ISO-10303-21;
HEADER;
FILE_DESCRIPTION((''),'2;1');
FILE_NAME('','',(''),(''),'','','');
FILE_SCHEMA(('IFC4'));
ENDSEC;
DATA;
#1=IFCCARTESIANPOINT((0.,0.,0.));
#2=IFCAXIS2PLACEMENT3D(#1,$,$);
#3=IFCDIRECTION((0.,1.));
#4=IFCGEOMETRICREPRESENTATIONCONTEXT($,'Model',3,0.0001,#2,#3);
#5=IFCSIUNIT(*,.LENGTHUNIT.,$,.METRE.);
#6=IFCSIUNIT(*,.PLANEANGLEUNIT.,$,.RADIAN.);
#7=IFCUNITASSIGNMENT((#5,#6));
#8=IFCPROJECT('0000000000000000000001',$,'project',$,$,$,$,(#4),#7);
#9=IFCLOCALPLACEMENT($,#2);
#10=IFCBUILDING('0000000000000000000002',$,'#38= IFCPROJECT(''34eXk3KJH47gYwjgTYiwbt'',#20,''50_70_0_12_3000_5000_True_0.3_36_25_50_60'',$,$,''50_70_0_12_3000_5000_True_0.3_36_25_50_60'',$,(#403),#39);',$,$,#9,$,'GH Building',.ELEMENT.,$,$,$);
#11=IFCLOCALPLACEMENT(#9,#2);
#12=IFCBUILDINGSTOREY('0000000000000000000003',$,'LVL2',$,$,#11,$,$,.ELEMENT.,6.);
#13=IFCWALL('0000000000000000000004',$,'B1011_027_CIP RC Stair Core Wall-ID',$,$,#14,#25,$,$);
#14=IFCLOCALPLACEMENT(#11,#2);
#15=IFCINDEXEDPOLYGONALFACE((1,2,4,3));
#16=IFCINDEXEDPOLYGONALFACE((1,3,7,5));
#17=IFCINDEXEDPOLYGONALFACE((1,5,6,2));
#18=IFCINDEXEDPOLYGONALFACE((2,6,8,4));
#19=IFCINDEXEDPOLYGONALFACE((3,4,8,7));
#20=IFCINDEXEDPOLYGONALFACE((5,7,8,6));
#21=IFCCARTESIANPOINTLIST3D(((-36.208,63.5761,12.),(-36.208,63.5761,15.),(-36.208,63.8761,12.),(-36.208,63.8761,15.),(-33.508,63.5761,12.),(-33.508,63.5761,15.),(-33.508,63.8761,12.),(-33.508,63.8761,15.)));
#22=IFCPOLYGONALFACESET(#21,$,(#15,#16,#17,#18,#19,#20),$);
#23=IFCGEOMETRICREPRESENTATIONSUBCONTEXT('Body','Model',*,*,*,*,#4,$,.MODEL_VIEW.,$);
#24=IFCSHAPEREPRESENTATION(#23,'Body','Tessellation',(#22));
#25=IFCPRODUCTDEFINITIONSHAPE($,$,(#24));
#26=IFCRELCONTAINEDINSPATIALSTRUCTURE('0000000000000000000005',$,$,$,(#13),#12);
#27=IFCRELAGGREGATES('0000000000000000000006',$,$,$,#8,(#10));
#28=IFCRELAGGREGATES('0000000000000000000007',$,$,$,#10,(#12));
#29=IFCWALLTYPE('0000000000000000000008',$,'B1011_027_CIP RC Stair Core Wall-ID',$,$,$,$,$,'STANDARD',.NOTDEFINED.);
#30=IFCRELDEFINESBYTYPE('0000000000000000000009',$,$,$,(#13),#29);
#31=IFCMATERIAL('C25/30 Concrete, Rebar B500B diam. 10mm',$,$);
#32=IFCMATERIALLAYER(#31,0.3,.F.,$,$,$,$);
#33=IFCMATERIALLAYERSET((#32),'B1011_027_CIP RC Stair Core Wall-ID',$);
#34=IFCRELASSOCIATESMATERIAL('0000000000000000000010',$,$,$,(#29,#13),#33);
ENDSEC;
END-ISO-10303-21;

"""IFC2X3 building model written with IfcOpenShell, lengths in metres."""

from ifc_helpers import new_model, si_unit, direction, frame, frame_2d, origin, place, context, subcontext, project, spatial, rectangle, extrude, material, layer, layer_set, layer_usage, type_object, element, save


model = new_model("IFC2X3")

# Units and contexts
model_context = context("Model", 3, precision=0.0001, world=origin(), true_north=direction((0.0, 1.0)))
body_context = subcontext(model_context, "Body", "Model", "MODEL_VIEW")
ifc_project = project(units=[si_unit("LENGTHUNIT", "METRE"), si_unit("PLANEANGLEUNIT", "RADIAN")], contexts=[model_context])

# Building, storey
building_placement = place(None, origin())
building = spatial("IfcBuilding", under=ifc_project, at=building_placement, Name="#38= IFCPROJECT('34eXk3KJH47gYwjgTYiwbt',#20,'50_70_0_12_3000_5000_True_0.3_36_25_50_60',$,$,'50_70_0_12_3000_5000_True_0.3_36_25_50_60',$,(#403),#39);", LongName="GH Building", CompositionType="ELEMENT")
storey_placement = place(building_placement, origin())
storey = spatial("IfcBuildingStorey", under=building, at=storey_placement, Name="LVL2", CompositionType="ELEMENT", Elevation=6.0)

# Wall
ifc_material_1 = material(Name="C25/30 Concrete, Rebar B500B diam. 10mm")
ifc_layer_1 = layer(ifc_material_1, 0.3, ventilated=False)
ifc_layer_set_1 = layer_set([ifc_layer_1], Name="B1011_027_CIP RC Stair Core Wall-ID")
wall_type_1 = type_object("IfcWallType", Name="B1011_027_CIP RC Stair Core Wall-ID", ElementType="STANDARD", PredefinedType="NOTDEFINED", material=ifc_layer_set_1)
ifc_layer_usage_1 = layer_usage(ifc_layer_set_1, "AXIS2", "POSITIVE", 0.0)
wall_1_placement = place(storey_placement, frame((-33.508, 63.8761, 12.0), z_axis=(0.0, 0.0, 1.0), x_axis=(-1.0, 0.0, 0.0)))
element("IfcWall", 1, at=wall_1_placement, inside=storey, type_object=wall_type_1, material=ifc_layer_usage_1, Name="B1011_027_CIP RC Stair Core Wall-ID", context=body_context, shape_type="SweptSolid", body=[
    extrude(rectangle(XDim=2.7, YDim=0.3, at=frame_2d((1.35, 0.15))), origin(), (0.0, 0.0, 1.0), 3.0),
])

save(model, "model.ifc")
